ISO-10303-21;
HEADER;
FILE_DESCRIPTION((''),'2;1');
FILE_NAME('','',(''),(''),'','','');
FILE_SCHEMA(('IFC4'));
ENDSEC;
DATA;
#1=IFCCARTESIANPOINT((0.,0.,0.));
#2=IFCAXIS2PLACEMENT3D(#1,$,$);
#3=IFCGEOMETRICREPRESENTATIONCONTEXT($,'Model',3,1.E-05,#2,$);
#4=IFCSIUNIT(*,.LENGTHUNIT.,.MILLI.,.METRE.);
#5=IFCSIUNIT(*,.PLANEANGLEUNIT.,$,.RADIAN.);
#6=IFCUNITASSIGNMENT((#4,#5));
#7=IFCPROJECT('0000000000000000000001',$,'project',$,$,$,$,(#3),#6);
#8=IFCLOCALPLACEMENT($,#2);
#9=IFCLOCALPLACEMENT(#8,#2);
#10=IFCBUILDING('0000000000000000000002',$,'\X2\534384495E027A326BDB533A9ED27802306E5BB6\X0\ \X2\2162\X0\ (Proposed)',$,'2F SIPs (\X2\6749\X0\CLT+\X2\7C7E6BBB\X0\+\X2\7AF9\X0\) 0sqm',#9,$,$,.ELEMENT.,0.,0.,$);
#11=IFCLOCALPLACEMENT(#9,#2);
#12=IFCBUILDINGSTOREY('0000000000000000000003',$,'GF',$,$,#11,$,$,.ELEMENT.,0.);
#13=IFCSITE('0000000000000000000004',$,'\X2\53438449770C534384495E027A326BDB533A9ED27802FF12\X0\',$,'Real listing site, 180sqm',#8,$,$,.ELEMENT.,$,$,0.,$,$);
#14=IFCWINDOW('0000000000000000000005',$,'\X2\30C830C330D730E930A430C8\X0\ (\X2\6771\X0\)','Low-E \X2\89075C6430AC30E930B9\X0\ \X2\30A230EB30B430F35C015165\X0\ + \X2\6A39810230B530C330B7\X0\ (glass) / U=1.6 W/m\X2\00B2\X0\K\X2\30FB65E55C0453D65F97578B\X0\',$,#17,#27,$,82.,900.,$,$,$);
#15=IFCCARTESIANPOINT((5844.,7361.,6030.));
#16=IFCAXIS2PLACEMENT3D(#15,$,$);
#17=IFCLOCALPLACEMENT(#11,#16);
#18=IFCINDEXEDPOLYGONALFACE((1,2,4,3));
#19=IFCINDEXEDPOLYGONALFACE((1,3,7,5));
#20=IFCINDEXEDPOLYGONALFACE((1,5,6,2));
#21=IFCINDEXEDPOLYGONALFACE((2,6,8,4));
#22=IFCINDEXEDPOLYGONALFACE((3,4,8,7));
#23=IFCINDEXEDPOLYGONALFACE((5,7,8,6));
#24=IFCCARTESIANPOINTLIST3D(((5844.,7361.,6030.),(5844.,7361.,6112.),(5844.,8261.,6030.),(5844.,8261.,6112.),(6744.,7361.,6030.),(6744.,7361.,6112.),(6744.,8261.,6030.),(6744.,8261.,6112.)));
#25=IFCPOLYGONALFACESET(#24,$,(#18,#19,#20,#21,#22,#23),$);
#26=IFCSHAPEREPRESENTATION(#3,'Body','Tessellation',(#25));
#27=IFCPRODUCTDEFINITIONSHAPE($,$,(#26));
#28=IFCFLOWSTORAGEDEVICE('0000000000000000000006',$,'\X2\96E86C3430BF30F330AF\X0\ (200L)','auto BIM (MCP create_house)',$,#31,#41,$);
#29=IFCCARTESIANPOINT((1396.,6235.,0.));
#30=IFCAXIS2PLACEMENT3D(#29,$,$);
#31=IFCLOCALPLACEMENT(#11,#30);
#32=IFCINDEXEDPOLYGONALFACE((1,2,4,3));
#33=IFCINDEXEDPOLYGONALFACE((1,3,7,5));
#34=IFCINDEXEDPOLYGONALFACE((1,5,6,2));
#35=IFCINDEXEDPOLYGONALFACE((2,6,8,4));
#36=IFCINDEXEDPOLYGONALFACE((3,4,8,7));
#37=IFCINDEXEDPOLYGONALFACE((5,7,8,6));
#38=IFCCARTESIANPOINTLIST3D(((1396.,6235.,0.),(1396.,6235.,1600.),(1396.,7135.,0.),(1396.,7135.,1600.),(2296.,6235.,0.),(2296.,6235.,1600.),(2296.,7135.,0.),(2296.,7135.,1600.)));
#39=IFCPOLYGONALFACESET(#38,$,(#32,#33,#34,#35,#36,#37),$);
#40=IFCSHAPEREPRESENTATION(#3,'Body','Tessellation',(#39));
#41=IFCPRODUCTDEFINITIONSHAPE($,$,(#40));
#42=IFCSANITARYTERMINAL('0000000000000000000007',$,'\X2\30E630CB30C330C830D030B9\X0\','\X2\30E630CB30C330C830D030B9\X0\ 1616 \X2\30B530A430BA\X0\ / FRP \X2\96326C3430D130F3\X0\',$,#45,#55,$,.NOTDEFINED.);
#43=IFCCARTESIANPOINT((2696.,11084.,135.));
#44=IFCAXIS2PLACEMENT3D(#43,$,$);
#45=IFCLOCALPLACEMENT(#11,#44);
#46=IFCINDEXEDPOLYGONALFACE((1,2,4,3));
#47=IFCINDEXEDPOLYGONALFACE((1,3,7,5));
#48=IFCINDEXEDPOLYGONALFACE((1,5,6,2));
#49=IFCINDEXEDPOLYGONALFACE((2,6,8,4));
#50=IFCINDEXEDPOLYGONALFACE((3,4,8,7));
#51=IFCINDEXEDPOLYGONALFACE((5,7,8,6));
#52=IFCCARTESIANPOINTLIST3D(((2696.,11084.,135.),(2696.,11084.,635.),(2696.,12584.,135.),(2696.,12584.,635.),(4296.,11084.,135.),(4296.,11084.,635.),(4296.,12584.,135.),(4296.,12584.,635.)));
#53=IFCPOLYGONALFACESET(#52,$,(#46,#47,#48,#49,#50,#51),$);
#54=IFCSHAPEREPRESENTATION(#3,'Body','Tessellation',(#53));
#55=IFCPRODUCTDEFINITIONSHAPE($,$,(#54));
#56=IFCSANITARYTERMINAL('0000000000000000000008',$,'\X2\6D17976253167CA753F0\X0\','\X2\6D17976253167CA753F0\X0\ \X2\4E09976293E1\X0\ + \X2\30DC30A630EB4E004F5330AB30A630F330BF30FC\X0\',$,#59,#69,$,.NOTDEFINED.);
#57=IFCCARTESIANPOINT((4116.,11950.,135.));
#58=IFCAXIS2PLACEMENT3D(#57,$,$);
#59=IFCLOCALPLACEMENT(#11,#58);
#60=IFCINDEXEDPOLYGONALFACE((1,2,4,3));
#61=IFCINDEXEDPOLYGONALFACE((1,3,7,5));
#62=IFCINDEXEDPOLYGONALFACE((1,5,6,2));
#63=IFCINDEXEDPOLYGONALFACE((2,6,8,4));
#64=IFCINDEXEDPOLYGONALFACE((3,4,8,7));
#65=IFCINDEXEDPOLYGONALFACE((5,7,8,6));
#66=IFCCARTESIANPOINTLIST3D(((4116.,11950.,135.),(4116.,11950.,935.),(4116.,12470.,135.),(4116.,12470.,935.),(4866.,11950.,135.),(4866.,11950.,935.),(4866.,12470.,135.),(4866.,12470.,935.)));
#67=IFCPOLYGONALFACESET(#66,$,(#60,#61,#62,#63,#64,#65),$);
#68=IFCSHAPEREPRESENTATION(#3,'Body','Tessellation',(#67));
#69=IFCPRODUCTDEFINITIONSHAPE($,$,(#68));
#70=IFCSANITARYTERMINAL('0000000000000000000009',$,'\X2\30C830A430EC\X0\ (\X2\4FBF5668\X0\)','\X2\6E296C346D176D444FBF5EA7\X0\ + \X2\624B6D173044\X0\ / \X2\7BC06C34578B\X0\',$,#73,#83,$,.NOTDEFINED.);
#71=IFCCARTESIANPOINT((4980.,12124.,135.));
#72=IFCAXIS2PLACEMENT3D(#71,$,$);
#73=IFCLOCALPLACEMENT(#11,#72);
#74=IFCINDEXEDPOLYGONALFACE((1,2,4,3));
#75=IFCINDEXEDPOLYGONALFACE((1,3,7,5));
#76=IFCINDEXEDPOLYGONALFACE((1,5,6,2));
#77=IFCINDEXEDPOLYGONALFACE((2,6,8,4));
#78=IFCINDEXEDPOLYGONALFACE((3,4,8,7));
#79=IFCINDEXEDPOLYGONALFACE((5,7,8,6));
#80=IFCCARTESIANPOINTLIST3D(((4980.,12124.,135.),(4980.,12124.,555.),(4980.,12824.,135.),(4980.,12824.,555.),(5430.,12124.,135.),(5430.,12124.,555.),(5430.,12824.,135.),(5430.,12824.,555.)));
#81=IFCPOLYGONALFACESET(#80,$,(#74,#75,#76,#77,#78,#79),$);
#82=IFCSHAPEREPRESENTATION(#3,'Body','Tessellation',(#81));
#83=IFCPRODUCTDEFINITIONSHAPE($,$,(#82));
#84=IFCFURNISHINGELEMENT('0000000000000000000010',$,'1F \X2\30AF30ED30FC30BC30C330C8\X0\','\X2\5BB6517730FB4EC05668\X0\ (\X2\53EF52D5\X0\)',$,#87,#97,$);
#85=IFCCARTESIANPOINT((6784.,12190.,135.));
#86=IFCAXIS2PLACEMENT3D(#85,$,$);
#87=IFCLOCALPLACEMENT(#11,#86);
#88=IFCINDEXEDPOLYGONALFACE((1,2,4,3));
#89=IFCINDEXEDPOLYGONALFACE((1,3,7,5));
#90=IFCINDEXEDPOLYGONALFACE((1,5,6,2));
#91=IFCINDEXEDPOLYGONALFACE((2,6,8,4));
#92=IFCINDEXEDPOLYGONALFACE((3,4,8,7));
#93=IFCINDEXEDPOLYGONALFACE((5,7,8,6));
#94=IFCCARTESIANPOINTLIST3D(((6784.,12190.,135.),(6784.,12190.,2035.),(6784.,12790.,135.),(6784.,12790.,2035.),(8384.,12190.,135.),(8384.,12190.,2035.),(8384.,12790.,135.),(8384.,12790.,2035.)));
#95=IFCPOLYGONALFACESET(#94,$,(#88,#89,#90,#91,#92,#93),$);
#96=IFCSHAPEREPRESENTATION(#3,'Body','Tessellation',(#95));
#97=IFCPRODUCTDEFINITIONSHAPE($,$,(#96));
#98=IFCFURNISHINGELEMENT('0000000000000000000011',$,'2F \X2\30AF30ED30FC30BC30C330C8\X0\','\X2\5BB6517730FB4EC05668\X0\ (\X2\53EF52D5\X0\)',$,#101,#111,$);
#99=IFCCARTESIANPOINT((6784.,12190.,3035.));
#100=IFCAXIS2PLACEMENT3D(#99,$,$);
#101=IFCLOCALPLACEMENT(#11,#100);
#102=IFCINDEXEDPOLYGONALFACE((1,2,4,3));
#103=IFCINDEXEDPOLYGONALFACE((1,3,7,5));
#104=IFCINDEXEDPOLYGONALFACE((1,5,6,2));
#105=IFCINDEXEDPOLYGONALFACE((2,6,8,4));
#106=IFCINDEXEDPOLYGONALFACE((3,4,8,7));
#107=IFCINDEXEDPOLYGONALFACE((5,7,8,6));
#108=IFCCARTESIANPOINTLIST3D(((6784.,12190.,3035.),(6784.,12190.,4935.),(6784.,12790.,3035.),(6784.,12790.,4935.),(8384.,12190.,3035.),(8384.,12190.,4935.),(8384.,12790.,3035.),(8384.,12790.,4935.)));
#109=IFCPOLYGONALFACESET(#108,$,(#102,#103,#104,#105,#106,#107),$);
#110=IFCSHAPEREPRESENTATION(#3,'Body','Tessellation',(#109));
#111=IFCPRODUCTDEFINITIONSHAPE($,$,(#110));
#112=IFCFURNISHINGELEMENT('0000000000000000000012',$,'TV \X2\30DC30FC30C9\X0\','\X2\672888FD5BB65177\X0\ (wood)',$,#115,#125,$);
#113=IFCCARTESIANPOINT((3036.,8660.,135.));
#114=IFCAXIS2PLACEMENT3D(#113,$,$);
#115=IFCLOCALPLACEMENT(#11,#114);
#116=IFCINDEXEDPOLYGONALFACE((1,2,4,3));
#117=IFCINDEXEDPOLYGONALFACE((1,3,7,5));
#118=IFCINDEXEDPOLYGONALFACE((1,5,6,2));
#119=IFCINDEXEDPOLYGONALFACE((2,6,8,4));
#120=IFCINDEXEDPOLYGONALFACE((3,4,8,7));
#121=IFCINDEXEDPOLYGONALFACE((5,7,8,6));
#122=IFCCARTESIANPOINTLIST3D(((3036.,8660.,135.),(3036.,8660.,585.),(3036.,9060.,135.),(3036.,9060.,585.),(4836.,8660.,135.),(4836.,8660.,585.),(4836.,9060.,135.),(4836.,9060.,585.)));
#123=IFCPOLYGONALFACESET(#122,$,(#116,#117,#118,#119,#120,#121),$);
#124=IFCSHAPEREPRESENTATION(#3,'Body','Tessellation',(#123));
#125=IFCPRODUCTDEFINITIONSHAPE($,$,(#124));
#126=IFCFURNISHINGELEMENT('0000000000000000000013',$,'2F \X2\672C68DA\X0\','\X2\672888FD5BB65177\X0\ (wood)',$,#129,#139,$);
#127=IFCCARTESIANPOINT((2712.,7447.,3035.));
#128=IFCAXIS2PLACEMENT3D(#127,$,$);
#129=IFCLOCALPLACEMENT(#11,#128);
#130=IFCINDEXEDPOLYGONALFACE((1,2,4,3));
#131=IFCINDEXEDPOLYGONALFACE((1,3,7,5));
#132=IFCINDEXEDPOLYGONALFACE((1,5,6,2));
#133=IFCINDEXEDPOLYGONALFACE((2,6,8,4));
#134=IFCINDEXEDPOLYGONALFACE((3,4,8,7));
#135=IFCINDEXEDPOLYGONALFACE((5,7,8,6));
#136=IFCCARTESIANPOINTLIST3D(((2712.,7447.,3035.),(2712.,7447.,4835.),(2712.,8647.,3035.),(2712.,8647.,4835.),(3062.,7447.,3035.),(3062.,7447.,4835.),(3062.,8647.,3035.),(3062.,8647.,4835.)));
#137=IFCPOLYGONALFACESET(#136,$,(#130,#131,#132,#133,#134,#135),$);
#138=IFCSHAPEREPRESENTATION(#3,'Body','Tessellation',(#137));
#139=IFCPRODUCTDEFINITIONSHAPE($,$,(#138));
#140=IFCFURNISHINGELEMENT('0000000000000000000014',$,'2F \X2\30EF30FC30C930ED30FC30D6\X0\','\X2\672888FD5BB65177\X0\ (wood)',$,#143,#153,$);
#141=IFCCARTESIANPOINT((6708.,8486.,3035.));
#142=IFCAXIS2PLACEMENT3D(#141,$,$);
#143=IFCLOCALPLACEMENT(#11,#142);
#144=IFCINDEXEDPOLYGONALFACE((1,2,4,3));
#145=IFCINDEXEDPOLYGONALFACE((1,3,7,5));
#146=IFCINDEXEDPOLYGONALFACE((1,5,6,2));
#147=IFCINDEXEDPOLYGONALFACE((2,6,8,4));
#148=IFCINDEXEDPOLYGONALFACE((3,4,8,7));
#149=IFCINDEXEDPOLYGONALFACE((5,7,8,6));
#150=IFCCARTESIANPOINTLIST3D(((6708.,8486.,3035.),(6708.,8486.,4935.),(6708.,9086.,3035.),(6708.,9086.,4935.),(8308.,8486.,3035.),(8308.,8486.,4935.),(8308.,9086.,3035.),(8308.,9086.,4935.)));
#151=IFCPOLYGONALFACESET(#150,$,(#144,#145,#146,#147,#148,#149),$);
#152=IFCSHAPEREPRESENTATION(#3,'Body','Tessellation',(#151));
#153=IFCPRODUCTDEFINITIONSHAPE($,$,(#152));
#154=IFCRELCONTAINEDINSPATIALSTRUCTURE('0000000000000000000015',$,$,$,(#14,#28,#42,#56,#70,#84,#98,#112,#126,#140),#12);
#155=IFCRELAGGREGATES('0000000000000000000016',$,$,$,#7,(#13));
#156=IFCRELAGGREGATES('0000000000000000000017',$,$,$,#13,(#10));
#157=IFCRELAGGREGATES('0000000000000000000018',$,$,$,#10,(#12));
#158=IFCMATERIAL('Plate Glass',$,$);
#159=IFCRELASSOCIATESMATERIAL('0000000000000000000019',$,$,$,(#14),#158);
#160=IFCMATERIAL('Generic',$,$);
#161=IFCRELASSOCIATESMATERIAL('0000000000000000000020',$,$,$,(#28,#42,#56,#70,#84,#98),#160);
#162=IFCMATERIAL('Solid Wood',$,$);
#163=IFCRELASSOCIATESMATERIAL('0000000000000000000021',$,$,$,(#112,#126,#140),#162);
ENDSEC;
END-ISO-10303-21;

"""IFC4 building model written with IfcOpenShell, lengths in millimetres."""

from ifc_helpers import new_model, si_unit, frame, frame_2d, origin, place, context, project, spatial, rectangle, extrude, material, element, save


model = new_model("IFC4")

# Units and contexts
model_context = context("Model", 3, precision=1e-05, world=origin())
ifc_project = project(units=[si_unit("LENGTHUNIT", "METRE", prefix="MILLI"), si_unit("PLANEANGLEUNIT", "RADIAN")], contexts=[model_context])

# Site, building, storey
site_placement = place(None, origin())
site = spatial("IfcSite", under=ifc_project, at=site_placement, Name="千葉県千葉市稲毛区黒砂２", ObjectType="Real listing site, 180sqm", CompositionType="ELEMENT", RefElevation=0.0)
building_placement = place(site_placement, origin())
building = spatial("IfcBuilding", under=site, at=building_placement, Name="千葉市稲毛区黒砂の家 Ⅲ (Proposed)", ObjectType="2F SIPs (杉CLT+籾殻+竹) 0sqm", CompositionType="ELEMENT", ElevationOfRefHeight=0.0, ElevationOfTerrain=0.0)
storey_placement = place(building_placement, origin())
storey = spatial("IfcBuildingStorey", under=building, at=storey_placement, Name="GF", CompositionType="ELEMENT", Elevation=0.0)

# Shared definitions
ifc_material_1 = material(Name="Solid Wood")
ifc_material_2 = material(Name="Plate Glass")

# Window
window_1_placement = place(storey_placement, frame((5844.0, 7361.0, 6030.0)))
element("IfcWindow", 1, at=window_1_placement, inside=storey, material=ifc_material_2, Name="トップライト (東)", Description="Low-E 複層ガラス アルゴン封入 + 樹脂サッシ (glass) / U=1.6 W/m²K・日射取得型", OverallHeight=82.0, OverallWidth=900.0, context=model_context, shape_type="SweptSolid", body=[
    extrude(rectangle(XDim=900.0, YDim=900.0, at=frame_2d((450.0, 450.0))), frame((5844.0, 7361.0, 6030.0)), (0.0, 0.0, 1.0), 82.0),
])

# Flow storage device
ifc_material_3 = material(Name="Generic")
flow_storage_device_placement = place(storey_placement, frame((1396.0, 6235.0, 0.0)))
element("IfcFlowStorageDevice", 2, at=flow_storage_device_placement, inside=storey, material=ifc_material_3, Name="雨水タンク (200L)", Description="auto BIM (MCP create_house)", context=model_context, shape_type="SweptSolid", body=[
    extrude(rectangle(XDim=900.0, YDim=900.0, at=frame_2d((450.0, 450.0))), frame((1396.0, 6235.0, 0.0)), (0.0, 0.0, 1.0), 1600.0),
])

# Sanitary terminals
sanitary_terminal_1_placement = place(storey_placement, frame((2696.0, 11084.0, 135.0)))
element("IfcSanitaryTerminal", 3, at=sanitary_terminal_1_placement, inside=storey, material=ifc_material_3, Name="ユニットバス", Description="ユニットバス 1616 サイズ / FRP 防水パン", PredefinedType="NOTDEFINED", context=model_context, shape_type="SweptSolid", body=[
    extrude(rectangle(XDim=1600.0, YDim=1500.0, at=frame_2d((800.0, 750.0))), frame((2696.0, 11084.0, 135.0)), (0.0, 0.0, 1.0), 500.0),
])
sanitary_terminal_2_placement = place(storey_placement, frame((4116.0, 11950.0, 135.0)))
element("IfcSanitaryTerminal", 4, at=sanitary_terminal_2_placement, inside=storey, material=ifc_material_3, Name="洗面化粧台", Description="洗面化粧台 三面鏡 + ボウル一体カウンター", PredefinedType="NOTDEFINED", context=model_context, shape_type="SweptSolid", body=[
    extrude(rectangle(XDim=750.0, YDim=520.0, at=frame_2d((375.0, 260.0))), frame((4116.0, 11950.0, 135.0)), (0.0, 0.0, 1.0), 800.0),
])
sanitary_terminal_3_placement = place(storey_placement, frame((4980.0, 12124.0, 135.0)))
element("IfcSanitaryTerminal", 5, at=sanitary_terminal_3_placement, inside=storey, material=ifc_material_3, Name="トイレ (便器)", Description="温水洗浄便座 + 手洗い / 節水型", PredefinedType="NOTDEFINED", context=model_context, shape_type="SweptSolid", body=[
    extrude(rectangle(XDim=450.0, YDim=700.0, at=frame_2d((225.0, 350.0))), frame((4980.0, 12124.0, 135.0)), (0.0, 0.0, 1.0), 420.0),
])

# Furnishing elements
furnishing_1_placement = place(storey_placement, frame((6784.0, 12190.0, 135.0)))
element("IfcFurnishingElement", 6, at=furnishing_1_placement, inside=storey, material=ifc_material_3, Name="1F クローゼット", Description="家具・什器 (可動)", context=model_context, shape_type="SweptSolid", body=[
    extrude(rectangle(XDim=1600.0, YDim=600.0, at=frame_2d((800.0, 300.0))), frame((6784.0, 12190.0, 135.0)), (0.0, 0.0, 1.0), 1900.0),
])
furnishing_2_placement = place(storey_placement, frame((6784.0, 12190.0, 3035.0)))
element("IfcFurnishingElement", 7, at=furnishing_2_placement, inside=storey, material=ifc_material_3, Name="2F クローゼット", Description="家具・什器 (可動)", context=model_context, shape_type="SweptSolid", body=[
    extrude(rectangle(XDim=1600.0, YDim=600.0, at=frame_2d((800.0, 300.0))), frame((6784.0, 12190.0, 3035.0)), (0.0, 0.0, 1.0), 1900.0),
])
furnishing_3_placement = place(storey_placement, frame((3036.0, 8660.0, 135.0)))
element("IfcFurnishingElement", 8, at=furnishing_3_placement, inside=storey, material=ifc_material_1, Name="TV ボード", Description="木製家具 (wood)", context=model_context, shape_type="SweptSolid", body=[
    extrude(rectangle(XDim=1800.0, YDim=400.0, at=frame_2d((900.0, 200.0))), frame((3036.0, 8660.0, 135.0)), (0.0, 0.0, 1.0), 450.0),
])
furnishing_4_placement = place(storey_placement, frame((2712.0, 7447.0, 3035.0)))
element("IfcFurnishingElement", 9, at=furnishing_4_placement, inside=storey, material=ifc_material_1, Name="2F 本棚", Description="木製家具 (wood)", context=model_context, shape_type="SweptSolid", body=[
    extrude(rectangle(XDim=350.0, YDim=1200.0, at=frame_2d((175.0, 600.0))), frame((2712.0, 7447.0, 3035.0)), (0.0, 0.0, 1.0), 1800.0),
])
furnishing_5_placement = place(storey_placement, frame((6708.0, 8486.0, 3035.0)))
element("IfcFurnishingElement", 10, at=furnishing_5_placement, inside=storey, material=ifc_material_1, Name="2F ワードローブ", Description="木製家具 (wood)", context=model_context, shape_type="SweptSolid", body=[
    extrude(rectangle(XDim=1600.0, YDim=600.0, at=frame_2d((800.0, 300.0))), frame((6708.0, 8486.0, 3035.0)), (0.0, 0.0, 1.0), 1900.0),
])

save(model, "model.ifc")
